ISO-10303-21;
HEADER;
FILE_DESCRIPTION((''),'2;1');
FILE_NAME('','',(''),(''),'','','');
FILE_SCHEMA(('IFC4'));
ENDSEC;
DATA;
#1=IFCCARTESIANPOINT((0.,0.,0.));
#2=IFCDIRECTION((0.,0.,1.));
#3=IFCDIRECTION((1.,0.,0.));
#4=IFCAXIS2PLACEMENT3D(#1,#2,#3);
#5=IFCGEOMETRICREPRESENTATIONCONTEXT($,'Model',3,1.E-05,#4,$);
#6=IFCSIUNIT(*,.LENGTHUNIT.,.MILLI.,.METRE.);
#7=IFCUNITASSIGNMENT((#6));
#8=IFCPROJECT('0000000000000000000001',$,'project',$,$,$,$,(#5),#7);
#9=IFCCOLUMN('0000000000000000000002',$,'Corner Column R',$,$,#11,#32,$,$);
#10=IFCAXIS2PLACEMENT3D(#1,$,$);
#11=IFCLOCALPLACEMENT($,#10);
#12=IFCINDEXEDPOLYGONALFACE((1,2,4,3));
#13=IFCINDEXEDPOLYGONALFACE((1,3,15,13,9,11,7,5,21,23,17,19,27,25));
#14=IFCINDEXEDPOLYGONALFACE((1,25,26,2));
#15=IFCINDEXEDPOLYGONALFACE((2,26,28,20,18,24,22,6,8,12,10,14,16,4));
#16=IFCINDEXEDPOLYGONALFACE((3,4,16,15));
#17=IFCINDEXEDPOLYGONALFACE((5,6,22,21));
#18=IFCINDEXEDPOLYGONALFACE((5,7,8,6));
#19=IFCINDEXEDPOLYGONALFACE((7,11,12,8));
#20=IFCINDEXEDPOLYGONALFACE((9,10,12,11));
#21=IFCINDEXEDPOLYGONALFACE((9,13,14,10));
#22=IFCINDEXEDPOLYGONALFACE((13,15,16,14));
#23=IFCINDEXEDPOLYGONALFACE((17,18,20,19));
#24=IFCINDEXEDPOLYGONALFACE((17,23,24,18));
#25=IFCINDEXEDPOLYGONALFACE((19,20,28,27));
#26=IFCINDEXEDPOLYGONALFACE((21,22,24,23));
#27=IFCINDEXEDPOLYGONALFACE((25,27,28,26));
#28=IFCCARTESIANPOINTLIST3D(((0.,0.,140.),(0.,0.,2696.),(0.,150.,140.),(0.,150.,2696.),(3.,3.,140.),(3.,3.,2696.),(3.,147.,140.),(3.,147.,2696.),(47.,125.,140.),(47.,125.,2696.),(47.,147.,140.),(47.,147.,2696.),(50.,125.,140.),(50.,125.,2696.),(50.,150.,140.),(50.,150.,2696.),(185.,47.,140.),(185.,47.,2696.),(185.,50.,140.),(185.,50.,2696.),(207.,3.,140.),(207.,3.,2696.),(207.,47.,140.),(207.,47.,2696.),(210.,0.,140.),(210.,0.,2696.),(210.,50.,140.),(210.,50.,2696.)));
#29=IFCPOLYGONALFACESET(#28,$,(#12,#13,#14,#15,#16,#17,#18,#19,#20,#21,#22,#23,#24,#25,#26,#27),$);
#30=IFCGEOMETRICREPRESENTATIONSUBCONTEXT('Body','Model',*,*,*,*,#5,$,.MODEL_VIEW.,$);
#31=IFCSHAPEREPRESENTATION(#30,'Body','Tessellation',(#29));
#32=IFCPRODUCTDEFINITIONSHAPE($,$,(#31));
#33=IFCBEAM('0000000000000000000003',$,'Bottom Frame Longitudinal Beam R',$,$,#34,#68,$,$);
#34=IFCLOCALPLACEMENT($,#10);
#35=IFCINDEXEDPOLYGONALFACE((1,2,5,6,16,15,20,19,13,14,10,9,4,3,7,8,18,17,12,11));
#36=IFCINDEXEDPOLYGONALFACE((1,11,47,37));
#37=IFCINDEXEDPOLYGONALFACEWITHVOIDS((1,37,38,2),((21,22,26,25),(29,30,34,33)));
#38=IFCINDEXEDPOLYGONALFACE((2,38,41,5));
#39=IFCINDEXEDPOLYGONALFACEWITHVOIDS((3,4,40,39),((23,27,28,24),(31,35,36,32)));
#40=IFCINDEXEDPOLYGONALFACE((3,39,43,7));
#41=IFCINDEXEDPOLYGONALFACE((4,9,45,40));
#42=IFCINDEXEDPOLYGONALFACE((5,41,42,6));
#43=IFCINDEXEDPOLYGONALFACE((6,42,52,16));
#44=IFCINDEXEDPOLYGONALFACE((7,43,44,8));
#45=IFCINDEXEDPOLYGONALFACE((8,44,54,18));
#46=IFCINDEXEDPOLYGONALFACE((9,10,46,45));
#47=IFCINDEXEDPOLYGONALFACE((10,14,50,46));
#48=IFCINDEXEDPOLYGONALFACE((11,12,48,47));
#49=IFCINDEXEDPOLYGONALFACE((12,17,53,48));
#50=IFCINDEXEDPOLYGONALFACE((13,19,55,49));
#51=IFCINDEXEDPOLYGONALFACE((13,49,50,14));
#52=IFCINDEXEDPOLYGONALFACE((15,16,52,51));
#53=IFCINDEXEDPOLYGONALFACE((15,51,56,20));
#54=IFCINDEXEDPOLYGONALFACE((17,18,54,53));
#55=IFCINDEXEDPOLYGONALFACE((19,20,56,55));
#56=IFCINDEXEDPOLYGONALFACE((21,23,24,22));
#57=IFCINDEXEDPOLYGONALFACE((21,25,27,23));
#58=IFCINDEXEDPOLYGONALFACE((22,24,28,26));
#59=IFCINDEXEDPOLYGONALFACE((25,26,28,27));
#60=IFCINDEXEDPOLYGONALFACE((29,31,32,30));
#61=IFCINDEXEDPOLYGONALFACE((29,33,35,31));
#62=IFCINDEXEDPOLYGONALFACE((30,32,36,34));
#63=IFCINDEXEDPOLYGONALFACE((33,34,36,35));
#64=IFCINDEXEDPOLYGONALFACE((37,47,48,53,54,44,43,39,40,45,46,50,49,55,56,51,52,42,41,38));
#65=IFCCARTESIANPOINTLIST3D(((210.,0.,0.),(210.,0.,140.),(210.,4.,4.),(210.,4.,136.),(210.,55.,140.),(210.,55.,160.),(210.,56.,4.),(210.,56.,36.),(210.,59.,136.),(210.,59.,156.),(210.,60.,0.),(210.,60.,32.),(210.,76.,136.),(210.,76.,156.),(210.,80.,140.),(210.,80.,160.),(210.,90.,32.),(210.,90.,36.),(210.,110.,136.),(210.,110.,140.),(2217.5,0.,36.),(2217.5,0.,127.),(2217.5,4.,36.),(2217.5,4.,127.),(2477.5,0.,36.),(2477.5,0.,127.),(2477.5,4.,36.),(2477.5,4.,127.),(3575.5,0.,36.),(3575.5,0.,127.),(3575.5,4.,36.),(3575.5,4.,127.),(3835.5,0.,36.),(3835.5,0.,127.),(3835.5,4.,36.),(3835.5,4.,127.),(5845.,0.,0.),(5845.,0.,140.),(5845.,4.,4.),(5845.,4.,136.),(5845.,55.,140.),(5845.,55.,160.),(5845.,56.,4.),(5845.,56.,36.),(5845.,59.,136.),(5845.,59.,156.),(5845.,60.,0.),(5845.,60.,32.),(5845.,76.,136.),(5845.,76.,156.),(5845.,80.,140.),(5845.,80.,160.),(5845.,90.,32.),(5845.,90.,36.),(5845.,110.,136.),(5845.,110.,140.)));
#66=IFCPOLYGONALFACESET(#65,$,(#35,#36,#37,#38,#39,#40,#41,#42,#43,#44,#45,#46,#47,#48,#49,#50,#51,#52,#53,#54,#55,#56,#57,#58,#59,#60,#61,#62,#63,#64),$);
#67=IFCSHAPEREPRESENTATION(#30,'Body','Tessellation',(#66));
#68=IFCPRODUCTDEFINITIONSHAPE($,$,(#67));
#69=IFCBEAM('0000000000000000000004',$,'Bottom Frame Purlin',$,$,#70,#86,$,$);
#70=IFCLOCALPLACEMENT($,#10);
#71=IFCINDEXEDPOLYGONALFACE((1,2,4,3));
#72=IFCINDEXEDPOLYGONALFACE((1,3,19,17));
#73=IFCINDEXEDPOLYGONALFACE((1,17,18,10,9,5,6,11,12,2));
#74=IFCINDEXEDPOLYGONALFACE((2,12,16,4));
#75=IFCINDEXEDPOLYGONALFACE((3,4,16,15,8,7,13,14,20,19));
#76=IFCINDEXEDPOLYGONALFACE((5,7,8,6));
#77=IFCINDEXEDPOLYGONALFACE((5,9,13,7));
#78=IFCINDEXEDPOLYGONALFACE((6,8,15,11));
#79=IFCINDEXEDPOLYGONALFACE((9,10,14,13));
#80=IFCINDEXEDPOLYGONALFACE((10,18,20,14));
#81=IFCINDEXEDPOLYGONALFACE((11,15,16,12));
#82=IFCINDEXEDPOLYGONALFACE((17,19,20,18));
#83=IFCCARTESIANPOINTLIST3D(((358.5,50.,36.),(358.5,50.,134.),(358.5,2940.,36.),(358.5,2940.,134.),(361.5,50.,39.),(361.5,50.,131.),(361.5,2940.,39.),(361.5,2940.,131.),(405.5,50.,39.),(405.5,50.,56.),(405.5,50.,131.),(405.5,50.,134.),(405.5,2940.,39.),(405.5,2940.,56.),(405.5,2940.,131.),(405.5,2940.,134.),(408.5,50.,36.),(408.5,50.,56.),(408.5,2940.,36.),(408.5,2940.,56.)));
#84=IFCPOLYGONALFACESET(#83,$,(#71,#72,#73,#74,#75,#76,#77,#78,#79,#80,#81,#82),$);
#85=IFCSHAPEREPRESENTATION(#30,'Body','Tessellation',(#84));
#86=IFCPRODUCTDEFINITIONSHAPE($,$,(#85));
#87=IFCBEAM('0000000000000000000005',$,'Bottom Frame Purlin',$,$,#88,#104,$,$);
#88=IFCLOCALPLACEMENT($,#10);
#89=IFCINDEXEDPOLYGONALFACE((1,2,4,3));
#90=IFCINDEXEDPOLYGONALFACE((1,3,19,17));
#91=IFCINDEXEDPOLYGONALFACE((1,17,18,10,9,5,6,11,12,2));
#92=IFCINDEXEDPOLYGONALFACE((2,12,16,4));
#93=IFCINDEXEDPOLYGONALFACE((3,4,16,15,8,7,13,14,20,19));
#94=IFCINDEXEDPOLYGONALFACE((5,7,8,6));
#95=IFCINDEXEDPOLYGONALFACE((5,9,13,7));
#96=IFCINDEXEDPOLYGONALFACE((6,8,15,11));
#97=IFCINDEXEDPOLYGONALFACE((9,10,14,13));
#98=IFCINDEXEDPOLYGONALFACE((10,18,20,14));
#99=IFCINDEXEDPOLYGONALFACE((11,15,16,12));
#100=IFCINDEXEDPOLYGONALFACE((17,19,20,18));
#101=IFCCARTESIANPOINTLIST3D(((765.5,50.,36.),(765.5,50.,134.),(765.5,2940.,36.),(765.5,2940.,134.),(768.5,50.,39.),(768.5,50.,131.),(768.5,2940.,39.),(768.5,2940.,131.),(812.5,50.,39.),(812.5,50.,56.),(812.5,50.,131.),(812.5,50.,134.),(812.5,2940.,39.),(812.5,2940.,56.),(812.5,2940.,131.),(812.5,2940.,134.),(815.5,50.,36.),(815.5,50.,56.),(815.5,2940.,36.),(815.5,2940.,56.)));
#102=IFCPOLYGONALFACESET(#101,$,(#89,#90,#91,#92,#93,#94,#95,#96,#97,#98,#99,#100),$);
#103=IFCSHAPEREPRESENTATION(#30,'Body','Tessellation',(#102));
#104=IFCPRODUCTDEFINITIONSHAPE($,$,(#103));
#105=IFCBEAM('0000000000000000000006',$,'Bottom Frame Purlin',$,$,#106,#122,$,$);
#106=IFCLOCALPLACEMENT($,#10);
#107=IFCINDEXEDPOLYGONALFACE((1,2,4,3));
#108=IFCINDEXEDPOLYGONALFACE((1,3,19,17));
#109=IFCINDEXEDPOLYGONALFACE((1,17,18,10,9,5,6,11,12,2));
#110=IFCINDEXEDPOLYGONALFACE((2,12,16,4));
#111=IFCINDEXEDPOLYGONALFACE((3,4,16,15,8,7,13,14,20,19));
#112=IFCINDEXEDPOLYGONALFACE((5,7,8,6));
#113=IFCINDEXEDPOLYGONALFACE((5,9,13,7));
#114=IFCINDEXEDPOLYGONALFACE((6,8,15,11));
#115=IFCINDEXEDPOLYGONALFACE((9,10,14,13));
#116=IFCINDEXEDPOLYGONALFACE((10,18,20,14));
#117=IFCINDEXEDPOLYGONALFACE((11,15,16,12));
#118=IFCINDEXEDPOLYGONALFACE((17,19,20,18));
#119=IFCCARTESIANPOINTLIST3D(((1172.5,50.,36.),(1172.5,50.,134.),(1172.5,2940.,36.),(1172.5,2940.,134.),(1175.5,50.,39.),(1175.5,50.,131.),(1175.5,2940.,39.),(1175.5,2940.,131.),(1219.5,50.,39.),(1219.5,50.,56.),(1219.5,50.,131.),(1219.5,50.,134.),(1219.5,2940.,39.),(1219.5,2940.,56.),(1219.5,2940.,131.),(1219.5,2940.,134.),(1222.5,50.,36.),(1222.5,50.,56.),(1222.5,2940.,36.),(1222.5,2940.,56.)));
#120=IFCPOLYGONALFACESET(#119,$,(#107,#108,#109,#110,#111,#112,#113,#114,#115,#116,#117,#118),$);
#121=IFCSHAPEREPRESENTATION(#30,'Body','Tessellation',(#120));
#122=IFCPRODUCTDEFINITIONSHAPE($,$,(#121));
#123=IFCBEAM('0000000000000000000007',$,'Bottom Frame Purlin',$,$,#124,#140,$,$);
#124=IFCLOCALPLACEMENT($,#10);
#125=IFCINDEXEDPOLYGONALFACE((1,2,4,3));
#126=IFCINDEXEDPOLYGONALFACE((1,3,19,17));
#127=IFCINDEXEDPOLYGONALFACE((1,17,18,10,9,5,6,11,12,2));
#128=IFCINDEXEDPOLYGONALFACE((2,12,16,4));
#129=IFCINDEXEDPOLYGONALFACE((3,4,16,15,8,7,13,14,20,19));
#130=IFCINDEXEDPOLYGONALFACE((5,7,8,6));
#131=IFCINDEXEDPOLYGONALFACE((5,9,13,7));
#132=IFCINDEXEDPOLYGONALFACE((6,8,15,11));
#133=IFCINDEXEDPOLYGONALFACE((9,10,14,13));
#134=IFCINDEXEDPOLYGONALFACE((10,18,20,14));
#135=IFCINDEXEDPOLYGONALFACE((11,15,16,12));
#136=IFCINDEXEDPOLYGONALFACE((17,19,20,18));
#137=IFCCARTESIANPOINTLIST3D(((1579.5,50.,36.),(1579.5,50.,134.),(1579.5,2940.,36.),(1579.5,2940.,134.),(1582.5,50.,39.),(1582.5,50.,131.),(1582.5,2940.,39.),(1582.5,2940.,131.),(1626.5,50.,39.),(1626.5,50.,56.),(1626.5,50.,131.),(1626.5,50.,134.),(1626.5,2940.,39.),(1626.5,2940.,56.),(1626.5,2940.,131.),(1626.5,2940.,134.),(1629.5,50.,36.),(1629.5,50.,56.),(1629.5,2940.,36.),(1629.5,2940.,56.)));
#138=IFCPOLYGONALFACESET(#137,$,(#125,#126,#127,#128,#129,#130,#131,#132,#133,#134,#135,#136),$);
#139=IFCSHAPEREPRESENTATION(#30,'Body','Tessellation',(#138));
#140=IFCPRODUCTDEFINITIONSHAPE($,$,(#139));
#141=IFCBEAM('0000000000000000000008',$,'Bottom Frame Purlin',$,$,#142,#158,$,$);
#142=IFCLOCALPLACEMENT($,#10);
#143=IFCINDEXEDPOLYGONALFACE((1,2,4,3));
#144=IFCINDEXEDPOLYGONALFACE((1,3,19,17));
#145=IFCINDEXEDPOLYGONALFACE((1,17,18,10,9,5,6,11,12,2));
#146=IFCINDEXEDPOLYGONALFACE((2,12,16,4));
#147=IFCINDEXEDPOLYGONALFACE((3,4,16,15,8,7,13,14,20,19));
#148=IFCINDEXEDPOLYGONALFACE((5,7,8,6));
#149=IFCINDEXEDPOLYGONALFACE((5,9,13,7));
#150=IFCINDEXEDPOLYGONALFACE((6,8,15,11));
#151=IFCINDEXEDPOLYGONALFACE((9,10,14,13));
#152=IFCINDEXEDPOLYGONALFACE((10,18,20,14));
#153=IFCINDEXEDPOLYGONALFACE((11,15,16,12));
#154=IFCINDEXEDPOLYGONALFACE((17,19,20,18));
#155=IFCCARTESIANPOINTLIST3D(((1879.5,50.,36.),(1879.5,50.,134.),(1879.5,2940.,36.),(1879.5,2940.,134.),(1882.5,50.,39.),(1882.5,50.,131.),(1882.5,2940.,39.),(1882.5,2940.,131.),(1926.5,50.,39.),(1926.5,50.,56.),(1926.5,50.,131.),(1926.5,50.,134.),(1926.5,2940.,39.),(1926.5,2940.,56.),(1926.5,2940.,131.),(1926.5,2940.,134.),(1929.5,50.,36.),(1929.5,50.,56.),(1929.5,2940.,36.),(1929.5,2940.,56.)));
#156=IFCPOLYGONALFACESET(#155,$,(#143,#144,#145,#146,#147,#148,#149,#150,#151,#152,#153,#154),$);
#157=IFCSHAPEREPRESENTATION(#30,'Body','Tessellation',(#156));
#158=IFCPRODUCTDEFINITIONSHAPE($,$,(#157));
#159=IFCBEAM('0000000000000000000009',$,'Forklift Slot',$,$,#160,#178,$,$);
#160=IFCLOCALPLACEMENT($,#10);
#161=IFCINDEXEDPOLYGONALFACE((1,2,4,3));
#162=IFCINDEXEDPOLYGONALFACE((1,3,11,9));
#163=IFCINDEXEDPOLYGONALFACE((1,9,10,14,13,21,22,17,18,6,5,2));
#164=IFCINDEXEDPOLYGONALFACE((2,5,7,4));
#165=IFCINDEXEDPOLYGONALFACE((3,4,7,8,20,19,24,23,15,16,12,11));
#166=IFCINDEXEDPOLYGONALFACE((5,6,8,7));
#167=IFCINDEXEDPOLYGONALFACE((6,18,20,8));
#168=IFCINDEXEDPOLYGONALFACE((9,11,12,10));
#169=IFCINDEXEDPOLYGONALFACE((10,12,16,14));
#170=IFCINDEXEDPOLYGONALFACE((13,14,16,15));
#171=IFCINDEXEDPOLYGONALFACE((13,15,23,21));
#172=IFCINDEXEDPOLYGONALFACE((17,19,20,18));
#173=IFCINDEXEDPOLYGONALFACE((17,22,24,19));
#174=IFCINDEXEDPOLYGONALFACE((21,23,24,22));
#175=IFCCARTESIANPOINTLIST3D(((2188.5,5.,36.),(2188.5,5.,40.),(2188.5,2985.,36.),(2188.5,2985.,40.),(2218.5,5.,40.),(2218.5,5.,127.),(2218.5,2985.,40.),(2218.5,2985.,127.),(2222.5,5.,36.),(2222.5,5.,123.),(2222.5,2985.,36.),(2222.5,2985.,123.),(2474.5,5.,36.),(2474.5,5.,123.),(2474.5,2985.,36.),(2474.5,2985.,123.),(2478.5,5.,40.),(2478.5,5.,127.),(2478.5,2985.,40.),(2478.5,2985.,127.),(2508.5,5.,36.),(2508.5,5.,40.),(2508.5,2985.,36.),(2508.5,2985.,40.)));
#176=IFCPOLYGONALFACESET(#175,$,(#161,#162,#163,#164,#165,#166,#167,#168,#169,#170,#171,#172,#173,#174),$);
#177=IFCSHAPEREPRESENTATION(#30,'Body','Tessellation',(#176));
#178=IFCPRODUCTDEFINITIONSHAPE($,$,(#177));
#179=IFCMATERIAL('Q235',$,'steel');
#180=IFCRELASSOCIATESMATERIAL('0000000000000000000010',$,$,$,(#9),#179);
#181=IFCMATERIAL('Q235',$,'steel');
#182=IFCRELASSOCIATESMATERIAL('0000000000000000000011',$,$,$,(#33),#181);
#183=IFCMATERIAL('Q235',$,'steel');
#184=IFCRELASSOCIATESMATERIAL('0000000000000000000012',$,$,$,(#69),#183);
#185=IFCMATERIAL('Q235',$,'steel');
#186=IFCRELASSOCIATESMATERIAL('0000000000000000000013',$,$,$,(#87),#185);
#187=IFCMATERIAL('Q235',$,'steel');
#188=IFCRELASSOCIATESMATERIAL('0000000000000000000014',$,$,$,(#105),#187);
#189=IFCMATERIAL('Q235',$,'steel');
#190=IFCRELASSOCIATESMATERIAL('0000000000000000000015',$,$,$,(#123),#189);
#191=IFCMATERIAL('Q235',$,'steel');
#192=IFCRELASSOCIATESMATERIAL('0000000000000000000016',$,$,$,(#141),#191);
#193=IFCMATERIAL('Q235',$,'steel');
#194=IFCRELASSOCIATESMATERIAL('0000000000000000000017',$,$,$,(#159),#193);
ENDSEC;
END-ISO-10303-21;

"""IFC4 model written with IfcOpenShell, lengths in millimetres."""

from ifc_helpers import new_model, si_unit, frame, origin_with_axes, place, context, subcontext, project, line, indexed_curve, outline, extrude, material, element, save


model = new_model("IFC4")

# Units and contexts
model_context = context("Model", 3, precision=1e-05, world=origin_with_axes())
body_context = subcontext(model_context, "Body", "Model", "MODEL_VIEW")
ifc_project = project(units=[si_unit("LENGTHUNIT", "METRE", prefix="MILLI")], contexts=[model_context])

# Column
ifc_material_1 = material(Name="Q235", Category="steel")
column_placement = place(None, frame((0.0, 0.0, 140.0), z_axis=(0.0, 0.0, 1.0), x_axis=(0.0, 1.0, 0.0)))
element("IfcColumn", 1, at=column_placement, material=ifc_material_1, Name="Corner Column R", context=body_context, shape_type="SweptSolid", body=[
    extrude(outline(indexed_curve([(0.0, 0.0), (0.0, -210.0), (50.0, -210.0), (50.0, -185.0), (47.0, -185.0), (47.0, -207.0), (3.0, -207.0), (3.0, -3.0), (147.0, -3.0), (147.0, -47.0), (125.0, -47.0), (125.0, -50.0), (150.0, -50.0), (150.0, 0.0), (0.0, 0.0)], segments=[line(1, 2, 3, 4, 5, 6, 7, 8, 9, 10, 11, 12, 13, 14, 15, 1)])), origin_with_axes(), (0.0, 0.0, 1.0), 2556.0),
])

# Beam, openings
ifc_material_2 = material(Name="Q235", Category="steel")
beam_1_placement = place(None, frame((210.0, 0.0, 0.0), z_axis=(1.0, 0.0, 0.0), x_axis=(0.0, 1.0, 0.0)))
beam_1 = element("IfcBeam", 2, at=beam_1_placement, material=ifc_material_2, Name="Bottom Frame Longitudinal Beam R", context=body_context, shape_type="SweptSolid", body=[
    extrude(outline(indexed_curve([(0.0, 0.0), (60.0, 0.0), (60.0, 32.0), (90.0, 32.0), (90.0, 36.0), (56.0, 36.0), (56.0, 4.0), (4.0, 4.0), (4.0, 136.0), (59.0, 136.0), (59.0, 156.0), (76.0, 156.0), (76.0, 136.0), (110.0, 136.0), (110.0, 140.0), (80.0, 140.0), (80.0, 160.0), (55.0, 160.0), (55.0, 140.0), (0.0, 140.0), (0.0, 0.0)], segments=[line(1, 2, 3, 4, 5, 6, 7, 8, 9, 10, 11, 12, 13, 14, 15, 16, 17, 18, 19, 20, 21, 1)])), origin_with_axes(), (0.0, 0.0, 1.0), 5635.0),
])
opening_1_placement = place(beam_1_placement, frame((0.0, 36.0, 2267.5), z_axis=(1.0, 0.0, 0.0), x_axis=(0.0, 0.0, -1.0)))
element("IfcOpeningElement", 3, at=opening_1_placement, cuts=beam_1, context=body_context, shape_type="SweptSolid", body=[
    extrude(outline(indexed_curve([(0.0, 0.0), (0.0, 91.0), (260.0, 91.0), (260.0, 0.0), (0.0, 0.0)], segments=[line(1, 2, 3, 4, 5, 1)])), origin_with_axes(), (0.0, 0.0, 1.0), 4.0),
])
opening_2_placement = place(beam_1_placement, frame((0.0, 36.0, 3625.5), z_axis=(1.0, 0.0, 0.0), x_axis=(0.0, 0.0, -1.0)))
element("IfcOpeningElement", 4, at=opening_2_placement, cuts=beam_1, context=body_context, shape_type="SweptSolid", body=[
    extrude(outline(indexed_curve([(0.0, 0.0), (0.0, 91.0), (260.0, 91.0), (260.0, 0.0), (0.0, 0.0)], segments=[line(1, 2, 3, 4, 5, 1)])), origin_with_axes(), (0.0, 0.0, 1.0), 4.0),
])

# Beams
ifc_material_3 = material(Name="Q235", Category="steel")
beam_2_placement = place(None, frame((358.5, 50.0, 36.0), z_axis=(0.0, 1.0, 0.0), x_axis=(1.0, 0.0, 0.0)))
element("IfcBeam", 5, at=beam_2_placement, material=ifc_material_3, Name="Bottom Frame Purlin", context=body_context, shape_type="SweptSolid", body=[
    extrude(outline(indexed_curve([(0.0, 0.0), (50.0, 0.0), (50.0, -20.0), (47.0, -20.0), (47.0, -3.0), (3.0, -3.0), (3.0, -95.0), (47.0, -95.0), (47.0, -138.0), (50.0, -78.0), (50.0, -98.0), (0.0, -98.0), (0.0, 0.0)], segments=[line(1, 2, 3, 4, 5, 6, 7, 8, 9, 10, 11, 12, 13, 1)])), origin_with_axes(), (0.0, 0.0, 1.0), 2890.0),
])
ifc_material_4 = material(Name="Q235", Category="steel")
beam_3_placement = place(None, frame((765.5, 50.0, 36.0), z_axis=(0.0, 1.0, 0.0), x_axis=(1.0, 0.0, 0.0)))
element("IfcBeam", 6, at=beam_3_placement, material=ifc_material_4, Name="Bottom Frame Purlin", context=body_context, shape_type="SweptSolid", body=[
    extrude(outline(indexed_curve([(0.0, 0.0), (50.0, 0.0), (50.0, -20.0), (47.0, -20.0), (47.0, -3.0), (3.0, -3.0), (3.0, -95.0), (47.0, -95.0), (47.0, -138.0), (50.0, -78.0), (50.0, -98.0), (0.0, -98.0), (0.0, 0.0)], segments=[line(1, 2, 3, 4, 5, 6, 7, 8, 9, 10, 11, 12, 13, 1)])), origin_with_axes(), (0.0, 0.0, 1.0), 2890.0),
])
ifc_material_5 = material(Name="Q235", Category="steel")
beam_4_placement = place(None, frame((1172.5, 50.0, 36.0), z_axis=(0.0, 1.0, 0.0), x_axis=(1.0, 0.0, 0.0)))
element("IfcBeam", 7, at=beam_4_placement, material=ifc_material_5, Name="Bottom Frame Purlin", context=body_context, shape_type="SweptSolid", body=[
    extrude(outline(indexed_curve([(0.0, 0.0), (50.0, 0.0), (50.0, -20.0), (47.0, -20.0), (47.0, -3.0), (3.0, -3.0), (3.0, -95.0), (47.0, -95.0), (47.0, -138.0), (50.0, -78.0), (50.0, -98.0), (0.0, -98.0), (0.0, 0.0)], segments=[line(1, 2, 3, 4, 5, 6, 7, 8, 9, 10, 11, 12, 13, 1)])), origin_with_axes(), (0.0, 0.0, 1.0), 2890.0),
])
ifc_material_6 = material(Name="Q235", Category="steel")
beam_5_placement = place(None, frame((1579.5, 50.0, 36.0), z_axis=(0.0, 1.0, 0.0), x_axis=(1.0, 0.0, 0.0)))
element("IfcBeam", 8, at=beam_5_placement, material=ifc_material_6, Name="Bottom Frame Purlin", context=body_context, shape_type="SweptSolid", body=[
    extrude(outline(indexed_curve([(0.0, 0.0), (50.0, 0.0), (50.0, -20.0), (47.0, -20.0), (47.0, -3.0), (3.0, -3.0), (3.0, -95.0), (47.0, -95.0), (47.0, -138.0), (50.0, -78.0), (50.0, -98.0), (0.0, -98.0), (0.0, 0.0)], segments=[line(1, 2, 3, 4, 5, 6, 7, 8, 9, 10, 11, 12, 13, 1)])), origin_with_axes(), (0.0, 0.0, 1.0), 2890.0),
])
ifc_material_7 = material(Name="Q235", Category="steel")
beam_6_placement = place(None, frame((1879.5, 50.0, 36.0), z_axis=(0.0, 1.0, 0.0), x_axis=(1.0, 0.0, 0.0)))
element("IfcBeam", 9, at=beam_6_placement, material=ifc_material_7, Name="Bottom Frame Purlin", context=body_context, shape_type="SweptSolid", body=[
    extrude(outline(indexed_curve([(0.0, 0.0), (50.0, 0.0), (50.0, -20.0), (47.0, -20.0), (47.0, -3.0), (3.0, -3.0), (3.0, -95.0), (47.0, -95.0), (47.0, -138.0), (50.0, -78.0), (50.0, -98.0), (0.0, -98.0), (0.0, 0.0)], segments=[line(1, 2, 3, 4, 5, 6, 7, 8, 9, 10, 11, 12, 13, 1)])), origin_with_axes(), (0.0, 0.0, 1.0), 2890.0),
])
ifc_material_8 = material(Name="Q235", Category="steel")
beam_7_placement = place(None, frame((2218.5, 5.0, 127.0), z_axis=(0.0, 1.0, 0.0), x_axis=(1.0, 0.0, 0.0)))
element("IfcBeam", 10, at=beam_7_placement, material=ifc_material_8, Name="Forklift Slot", context=body_context, shape_type="SweptSolid", body=[
    extrude(outline(indexed_curve([(0.0, 0.0), (260.0, 0.0), (260.0, 87.0), (290.0, 87.0), (290.0, 91.0), (256.0, 91.0), (256.0, 4.0), (4.0, 4.0), (4.0, 91.0), (-30.0, 91.0), (-30.0, 87.0), (0.0, 87.0), (0.0, 0.0)], segments=[line(1, 2, 3, 4, 5, 6, 7, 8, 9, 10, 11, 12, 13, 1)])), origin_with_axes(), (0.0, 0.0, 1.0), 2980.0),
])

save(model, "model.ifc")
